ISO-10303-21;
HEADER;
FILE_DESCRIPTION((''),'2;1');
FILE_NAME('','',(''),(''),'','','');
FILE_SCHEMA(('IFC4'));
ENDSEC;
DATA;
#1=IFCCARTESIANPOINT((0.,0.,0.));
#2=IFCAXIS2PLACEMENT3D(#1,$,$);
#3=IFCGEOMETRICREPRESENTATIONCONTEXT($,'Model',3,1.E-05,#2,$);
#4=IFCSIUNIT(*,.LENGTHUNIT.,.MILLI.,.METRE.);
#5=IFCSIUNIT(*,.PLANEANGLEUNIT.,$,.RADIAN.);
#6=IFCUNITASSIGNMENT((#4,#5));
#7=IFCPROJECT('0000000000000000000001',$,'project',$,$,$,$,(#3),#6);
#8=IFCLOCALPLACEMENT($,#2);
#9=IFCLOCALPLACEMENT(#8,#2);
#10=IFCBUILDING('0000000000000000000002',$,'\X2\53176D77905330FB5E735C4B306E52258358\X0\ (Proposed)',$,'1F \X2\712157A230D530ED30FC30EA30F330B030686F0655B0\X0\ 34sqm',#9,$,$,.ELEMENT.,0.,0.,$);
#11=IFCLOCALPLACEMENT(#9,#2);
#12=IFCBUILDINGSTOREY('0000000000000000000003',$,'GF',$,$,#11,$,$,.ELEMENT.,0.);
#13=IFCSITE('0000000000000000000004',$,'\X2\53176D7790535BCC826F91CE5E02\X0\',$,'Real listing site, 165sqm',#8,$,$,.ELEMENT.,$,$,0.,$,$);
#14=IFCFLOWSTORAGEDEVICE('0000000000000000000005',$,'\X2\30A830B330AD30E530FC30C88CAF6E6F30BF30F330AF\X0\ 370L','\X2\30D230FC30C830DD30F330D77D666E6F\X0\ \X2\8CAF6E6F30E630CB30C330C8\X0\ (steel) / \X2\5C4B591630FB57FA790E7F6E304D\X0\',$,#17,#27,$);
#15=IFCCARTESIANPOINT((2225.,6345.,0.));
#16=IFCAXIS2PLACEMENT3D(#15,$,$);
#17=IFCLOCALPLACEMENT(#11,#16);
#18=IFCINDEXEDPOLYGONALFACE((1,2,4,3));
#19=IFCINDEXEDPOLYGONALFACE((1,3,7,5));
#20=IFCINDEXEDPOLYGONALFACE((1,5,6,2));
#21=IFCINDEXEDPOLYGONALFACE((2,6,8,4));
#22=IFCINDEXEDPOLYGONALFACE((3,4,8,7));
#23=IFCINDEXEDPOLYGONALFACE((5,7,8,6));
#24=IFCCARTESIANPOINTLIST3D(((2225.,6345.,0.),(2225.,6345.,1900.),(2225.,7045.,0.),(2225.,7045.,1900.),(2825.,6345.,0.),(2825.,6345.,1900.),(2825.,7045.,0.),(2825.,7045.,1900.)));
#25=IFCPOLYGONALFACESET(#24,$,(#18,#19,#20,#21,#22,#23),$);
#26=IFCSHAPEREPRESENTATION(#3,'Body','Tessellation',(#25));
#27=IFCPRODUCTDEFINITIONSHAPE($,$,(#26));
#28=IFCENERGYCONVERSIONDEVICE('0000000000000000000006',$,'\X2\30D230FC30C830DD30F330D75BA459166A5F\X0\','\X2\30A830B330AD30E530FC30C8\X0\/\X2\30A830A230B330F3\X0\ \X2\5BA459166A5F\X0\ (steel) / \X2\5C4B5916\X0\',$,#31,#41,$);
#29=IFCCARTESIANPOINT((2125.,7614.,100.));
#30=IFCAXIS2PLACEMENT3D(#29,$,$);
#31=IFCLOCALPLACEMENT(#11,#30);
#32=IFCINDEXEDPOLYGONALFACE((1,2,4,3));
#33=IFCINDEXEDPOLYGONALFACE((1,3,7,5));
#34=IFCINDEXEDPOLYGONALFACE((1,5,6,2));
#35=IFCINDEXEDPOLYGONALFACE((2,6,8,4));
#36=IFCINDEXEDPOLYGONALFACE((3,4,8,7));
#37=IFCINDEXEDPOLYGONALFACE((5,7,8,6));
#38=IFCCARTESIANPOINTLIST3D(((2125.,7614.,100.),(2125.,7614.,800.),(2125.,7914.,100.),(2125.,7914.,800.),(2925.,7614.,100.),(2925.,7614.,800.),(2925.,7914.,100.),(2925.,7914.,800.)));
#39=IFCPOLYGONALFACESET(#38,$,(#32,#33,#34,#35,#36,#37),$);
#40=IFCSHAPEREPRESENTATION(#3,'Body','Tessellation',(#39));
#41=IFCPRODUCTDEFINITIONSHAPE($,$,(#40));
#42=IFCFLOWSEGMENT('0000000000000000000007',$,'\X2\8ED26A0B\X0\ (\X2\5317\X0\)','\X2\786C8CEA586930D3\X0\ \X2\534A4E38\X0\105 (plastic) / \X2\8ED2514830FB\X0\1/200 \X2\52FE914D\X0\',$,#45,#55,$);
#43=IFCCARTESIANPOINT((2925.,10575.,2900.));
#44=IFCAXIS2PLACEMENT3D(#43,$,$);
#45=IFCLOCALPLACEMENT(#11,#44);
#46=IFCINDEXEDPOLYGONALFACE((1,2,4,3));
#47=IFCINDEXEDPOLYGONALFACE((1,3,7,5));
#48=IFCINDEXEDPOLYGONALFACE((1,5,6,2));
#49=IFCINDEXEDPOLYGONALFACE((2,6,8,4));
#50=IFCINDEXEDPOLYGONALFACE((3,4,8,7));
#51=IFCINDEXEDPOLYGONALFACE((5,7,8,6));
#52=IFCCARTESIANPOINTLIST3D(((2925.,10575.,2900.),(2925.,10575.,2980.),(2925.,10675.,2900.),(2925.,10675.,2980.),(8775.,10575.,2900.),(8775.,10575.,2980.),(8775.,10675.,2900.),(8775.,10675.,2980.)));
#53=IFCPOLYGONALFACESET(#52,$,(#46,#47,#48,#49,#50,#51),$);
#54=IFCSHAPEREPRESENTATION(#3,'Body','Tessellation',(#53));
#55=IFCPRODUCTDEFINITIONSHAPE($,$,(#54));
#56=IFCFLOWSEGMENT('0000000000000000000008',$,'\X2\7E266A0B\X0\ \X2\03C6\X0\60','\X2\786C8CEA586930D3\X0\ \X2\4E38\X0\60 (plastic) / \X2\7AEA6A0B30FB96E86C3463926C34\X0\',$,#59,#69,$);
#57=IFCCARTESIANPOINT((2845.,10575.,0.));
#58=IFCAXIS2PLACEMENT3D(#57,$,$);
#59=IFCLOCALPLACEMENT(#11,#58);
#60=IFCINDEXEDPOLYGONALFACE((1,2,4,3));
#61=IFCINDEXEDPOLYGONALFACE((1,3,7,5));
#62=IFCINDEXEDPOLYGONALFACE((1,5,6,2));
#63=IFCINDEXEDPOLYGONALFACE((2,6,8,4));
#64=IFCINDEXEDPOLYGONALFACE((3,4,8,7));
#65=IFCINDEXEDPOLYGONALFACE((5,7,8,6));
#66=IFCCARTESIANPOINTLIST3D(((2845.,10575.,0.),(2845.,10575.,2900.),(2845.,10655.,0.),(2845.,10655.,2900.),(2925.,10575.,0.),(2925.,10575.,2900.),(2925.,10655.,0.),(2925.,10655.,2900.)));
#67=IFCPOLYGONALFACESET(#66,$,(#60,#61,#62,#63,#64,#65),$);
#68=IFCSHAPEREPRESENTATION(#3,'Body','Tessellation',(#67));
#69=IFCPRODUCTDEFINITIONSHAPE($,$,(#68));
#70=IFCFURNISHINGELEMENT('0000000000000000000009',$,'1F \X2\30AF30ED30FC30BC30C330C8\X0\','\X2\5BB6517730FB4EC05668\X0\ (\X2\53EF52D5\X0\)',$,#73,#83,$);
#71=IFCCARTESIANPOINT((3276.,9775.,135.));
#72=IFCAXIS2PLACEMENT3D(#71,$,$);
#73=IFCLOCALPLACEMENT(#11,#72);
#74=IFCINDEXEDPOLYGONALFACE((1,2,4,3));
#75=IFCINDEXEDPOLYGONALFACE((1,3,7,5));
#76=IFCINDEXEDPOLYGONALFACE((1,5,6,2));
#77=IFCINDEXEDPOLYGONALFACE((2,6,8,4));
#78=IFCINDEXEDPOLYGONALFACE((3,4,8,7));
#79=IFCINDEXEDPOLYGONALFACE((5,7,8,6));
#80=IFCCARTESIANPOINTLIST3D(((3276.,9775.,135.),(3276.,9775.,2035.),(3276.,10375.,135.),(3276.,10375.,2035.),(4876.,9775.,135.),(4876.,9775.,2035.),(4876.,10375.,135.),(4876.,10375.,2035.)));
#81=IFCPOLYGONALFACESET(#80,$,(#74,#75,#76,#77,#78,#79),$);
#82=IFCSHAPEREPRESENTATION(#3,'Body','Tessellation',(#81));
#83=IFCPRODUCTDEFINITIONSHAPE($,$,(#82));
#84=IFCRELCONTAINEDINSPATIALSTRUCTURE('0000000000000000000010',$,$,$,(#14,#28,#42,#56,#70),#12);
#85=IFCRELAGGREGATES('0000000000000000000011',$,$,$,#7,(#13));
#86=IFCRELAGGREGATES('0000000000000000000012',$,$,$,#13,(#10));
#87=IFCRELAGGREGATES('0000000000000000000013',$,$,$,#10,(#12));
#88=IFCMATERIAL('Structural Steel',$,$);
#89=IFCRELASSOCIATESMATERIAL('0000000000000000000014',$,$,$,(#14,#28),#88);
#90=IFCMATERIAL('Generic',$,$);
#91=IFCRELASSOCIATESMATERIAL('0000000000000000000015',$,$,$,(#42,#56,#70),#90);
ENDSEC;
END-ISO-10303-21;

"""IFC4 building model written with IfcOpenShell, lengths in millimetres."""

from ifc_helpers import new_model, si_unit, frame, frame_2d, origin, place, context, project, spatial, rectangle, extrude, material, element, save


model = new_model("IFC4")

# Units and contexts
model_context = context("Model", 3, precision=1e-05, world=origin())
ifc_project = project(units=[si_unit("LENGTHUNIT", "METRE", prefix="MILLI"), si_unit("PLANEANGLEUNIT", "RADIAN")], contexts=[model_context])

# Site, building, storey
site_placement = place(None, origin())
site = spatial("IfcSite", under=ifc_project, at=site_placement, Name="北海道富良野市", ObjectType="Real listing site, 165sqm", CompositionType="ELEMENT", RefElevation=0.0)
building_placement = place(site_placement, origin())
building = spatial("IfcBuilding", under=site, at=building_placement, Name="北海道・平屋の別荘 (Proposed)", ObjectType="1F 無垢フローリングと漆喰 34sqm", CompositionType="ELEMENT", ElevationOfRefHeight=0.0, ElevationOfTerrain=0.0)
storey_placement = place(building_placement, origin())
storey = spatial("IfcBuildingStorey", under=building, at=storey_placement, Name="GF", CompositionType="ELEMENT", Elevation=0.0)

# Shared definitions
ifc_material_1 = material(Name="Structural Steel")

# Shared definitions
ifc_material_2 = material(Name="Generic")

# Flow storage device
flow_storage_device_placement = place(storey_placement, frame((2225.0, 6345.0, 0.0)))
element("IfcFlowStorageDevice", 1, at=flow_storage_device_placement, inside=storey, material=ifc_material_1, Name="エコキュート貯湯タンク 370L", Description="ヒートポンプ給湯 貯湯ユニット (steel) / 屋外・基礎置き", context=model_context, shape_type="SweptSolid", body=[
    extrude(rectangle(XDim=600.0, YDim=700.0, at=frame_2d((300.0, 350.0))), frame((2225.0, 6345.0, 0.0)), (0.0, 0.0, 1.0), 1900.0),
])

# Energy conversion device
energy_conversion_device_placement = place(storey_placement, frame((2125.0, 7614.0, 100.0)))
element("IfcEnergyConversionDevice", 2, at=energy_conversion_device_placement, inside=storey, material=ifc_material_1, Name="ヒートポンプ室外機", Description="エコキュート/エアコン 室外機 (steel) / 屋外", context=model_context, shape_type="SweptSolid", body=[
    extrude(rectangle(XDim=800.0, YDim=300.0, at=frame_2d((400.0, 150.0))), frame((2125.0, 7614.0, 100.0)), (0.0, 0.0, 1.0), 700.0),
])

# Flow segments
flow_segment_1_placement = place(storey_placement, frame((2925.0, 10575.0, 2900.0)))
element("IfcFlowSegment", 3, at=flow_segment_1_placement, inside=storey, material=ifc_material_2, Name="軒樋 (北)", Description="硬質塩ビ 半丸105 (plastic) / 軒先・1/200 勾配", context=model_context, shape_type="SweptSolid", body=[
    extrude(rectangle(XDim=5850.0, YDim=100.0, at=frame_2d((2925.0, 50.0))), frame((2925.0, 10575.0, 2900.0)), (0.0, 0.0, 1.0), 80.0),
])
flow_segment_2_placement = place(storey_placement, frame((2845.0, 10575.0, 0.0)))
element("IfcFlowSegment", 4, at=flow_segment_2_placement, inside=storey, material=ifc_material_2, Name="縦樋 φ60", Description="硬質塩ビ 丸60 (plastic) / 竪樋・雨水排水", context=model_context, shape_type="SweptSolid", body=[
    extrude(rectangle(XDim=80.0, YDim=80.0, at=frame_2d((40.0, 40.0))), frame((2845.0, 10575.0, 0.0)), (0.0, 0.0, 1.0), 2900.0),
])

# Furnishing element
furnishing_placement = place(storey_placement, frame((3276.0, 9775.0, 135.0)))
element("IfcFurnishingElement", 5, at=furnishing_placement, inside=storey, material=ifc_material_2, Name="1F クローゼット", Description="家具・什器 (可動)", context=model_context, shape_type="SweptSolid", body=[
    extrude(rectangle(XDim=1600.0, YDim=600.0, at=frame_2d((800.0, 300.0))), frame((3276.0, 9775.0, 135.0)), (0.0, 0.0, 1.0), 1900.0),
])

save(model, "model.ifc")
